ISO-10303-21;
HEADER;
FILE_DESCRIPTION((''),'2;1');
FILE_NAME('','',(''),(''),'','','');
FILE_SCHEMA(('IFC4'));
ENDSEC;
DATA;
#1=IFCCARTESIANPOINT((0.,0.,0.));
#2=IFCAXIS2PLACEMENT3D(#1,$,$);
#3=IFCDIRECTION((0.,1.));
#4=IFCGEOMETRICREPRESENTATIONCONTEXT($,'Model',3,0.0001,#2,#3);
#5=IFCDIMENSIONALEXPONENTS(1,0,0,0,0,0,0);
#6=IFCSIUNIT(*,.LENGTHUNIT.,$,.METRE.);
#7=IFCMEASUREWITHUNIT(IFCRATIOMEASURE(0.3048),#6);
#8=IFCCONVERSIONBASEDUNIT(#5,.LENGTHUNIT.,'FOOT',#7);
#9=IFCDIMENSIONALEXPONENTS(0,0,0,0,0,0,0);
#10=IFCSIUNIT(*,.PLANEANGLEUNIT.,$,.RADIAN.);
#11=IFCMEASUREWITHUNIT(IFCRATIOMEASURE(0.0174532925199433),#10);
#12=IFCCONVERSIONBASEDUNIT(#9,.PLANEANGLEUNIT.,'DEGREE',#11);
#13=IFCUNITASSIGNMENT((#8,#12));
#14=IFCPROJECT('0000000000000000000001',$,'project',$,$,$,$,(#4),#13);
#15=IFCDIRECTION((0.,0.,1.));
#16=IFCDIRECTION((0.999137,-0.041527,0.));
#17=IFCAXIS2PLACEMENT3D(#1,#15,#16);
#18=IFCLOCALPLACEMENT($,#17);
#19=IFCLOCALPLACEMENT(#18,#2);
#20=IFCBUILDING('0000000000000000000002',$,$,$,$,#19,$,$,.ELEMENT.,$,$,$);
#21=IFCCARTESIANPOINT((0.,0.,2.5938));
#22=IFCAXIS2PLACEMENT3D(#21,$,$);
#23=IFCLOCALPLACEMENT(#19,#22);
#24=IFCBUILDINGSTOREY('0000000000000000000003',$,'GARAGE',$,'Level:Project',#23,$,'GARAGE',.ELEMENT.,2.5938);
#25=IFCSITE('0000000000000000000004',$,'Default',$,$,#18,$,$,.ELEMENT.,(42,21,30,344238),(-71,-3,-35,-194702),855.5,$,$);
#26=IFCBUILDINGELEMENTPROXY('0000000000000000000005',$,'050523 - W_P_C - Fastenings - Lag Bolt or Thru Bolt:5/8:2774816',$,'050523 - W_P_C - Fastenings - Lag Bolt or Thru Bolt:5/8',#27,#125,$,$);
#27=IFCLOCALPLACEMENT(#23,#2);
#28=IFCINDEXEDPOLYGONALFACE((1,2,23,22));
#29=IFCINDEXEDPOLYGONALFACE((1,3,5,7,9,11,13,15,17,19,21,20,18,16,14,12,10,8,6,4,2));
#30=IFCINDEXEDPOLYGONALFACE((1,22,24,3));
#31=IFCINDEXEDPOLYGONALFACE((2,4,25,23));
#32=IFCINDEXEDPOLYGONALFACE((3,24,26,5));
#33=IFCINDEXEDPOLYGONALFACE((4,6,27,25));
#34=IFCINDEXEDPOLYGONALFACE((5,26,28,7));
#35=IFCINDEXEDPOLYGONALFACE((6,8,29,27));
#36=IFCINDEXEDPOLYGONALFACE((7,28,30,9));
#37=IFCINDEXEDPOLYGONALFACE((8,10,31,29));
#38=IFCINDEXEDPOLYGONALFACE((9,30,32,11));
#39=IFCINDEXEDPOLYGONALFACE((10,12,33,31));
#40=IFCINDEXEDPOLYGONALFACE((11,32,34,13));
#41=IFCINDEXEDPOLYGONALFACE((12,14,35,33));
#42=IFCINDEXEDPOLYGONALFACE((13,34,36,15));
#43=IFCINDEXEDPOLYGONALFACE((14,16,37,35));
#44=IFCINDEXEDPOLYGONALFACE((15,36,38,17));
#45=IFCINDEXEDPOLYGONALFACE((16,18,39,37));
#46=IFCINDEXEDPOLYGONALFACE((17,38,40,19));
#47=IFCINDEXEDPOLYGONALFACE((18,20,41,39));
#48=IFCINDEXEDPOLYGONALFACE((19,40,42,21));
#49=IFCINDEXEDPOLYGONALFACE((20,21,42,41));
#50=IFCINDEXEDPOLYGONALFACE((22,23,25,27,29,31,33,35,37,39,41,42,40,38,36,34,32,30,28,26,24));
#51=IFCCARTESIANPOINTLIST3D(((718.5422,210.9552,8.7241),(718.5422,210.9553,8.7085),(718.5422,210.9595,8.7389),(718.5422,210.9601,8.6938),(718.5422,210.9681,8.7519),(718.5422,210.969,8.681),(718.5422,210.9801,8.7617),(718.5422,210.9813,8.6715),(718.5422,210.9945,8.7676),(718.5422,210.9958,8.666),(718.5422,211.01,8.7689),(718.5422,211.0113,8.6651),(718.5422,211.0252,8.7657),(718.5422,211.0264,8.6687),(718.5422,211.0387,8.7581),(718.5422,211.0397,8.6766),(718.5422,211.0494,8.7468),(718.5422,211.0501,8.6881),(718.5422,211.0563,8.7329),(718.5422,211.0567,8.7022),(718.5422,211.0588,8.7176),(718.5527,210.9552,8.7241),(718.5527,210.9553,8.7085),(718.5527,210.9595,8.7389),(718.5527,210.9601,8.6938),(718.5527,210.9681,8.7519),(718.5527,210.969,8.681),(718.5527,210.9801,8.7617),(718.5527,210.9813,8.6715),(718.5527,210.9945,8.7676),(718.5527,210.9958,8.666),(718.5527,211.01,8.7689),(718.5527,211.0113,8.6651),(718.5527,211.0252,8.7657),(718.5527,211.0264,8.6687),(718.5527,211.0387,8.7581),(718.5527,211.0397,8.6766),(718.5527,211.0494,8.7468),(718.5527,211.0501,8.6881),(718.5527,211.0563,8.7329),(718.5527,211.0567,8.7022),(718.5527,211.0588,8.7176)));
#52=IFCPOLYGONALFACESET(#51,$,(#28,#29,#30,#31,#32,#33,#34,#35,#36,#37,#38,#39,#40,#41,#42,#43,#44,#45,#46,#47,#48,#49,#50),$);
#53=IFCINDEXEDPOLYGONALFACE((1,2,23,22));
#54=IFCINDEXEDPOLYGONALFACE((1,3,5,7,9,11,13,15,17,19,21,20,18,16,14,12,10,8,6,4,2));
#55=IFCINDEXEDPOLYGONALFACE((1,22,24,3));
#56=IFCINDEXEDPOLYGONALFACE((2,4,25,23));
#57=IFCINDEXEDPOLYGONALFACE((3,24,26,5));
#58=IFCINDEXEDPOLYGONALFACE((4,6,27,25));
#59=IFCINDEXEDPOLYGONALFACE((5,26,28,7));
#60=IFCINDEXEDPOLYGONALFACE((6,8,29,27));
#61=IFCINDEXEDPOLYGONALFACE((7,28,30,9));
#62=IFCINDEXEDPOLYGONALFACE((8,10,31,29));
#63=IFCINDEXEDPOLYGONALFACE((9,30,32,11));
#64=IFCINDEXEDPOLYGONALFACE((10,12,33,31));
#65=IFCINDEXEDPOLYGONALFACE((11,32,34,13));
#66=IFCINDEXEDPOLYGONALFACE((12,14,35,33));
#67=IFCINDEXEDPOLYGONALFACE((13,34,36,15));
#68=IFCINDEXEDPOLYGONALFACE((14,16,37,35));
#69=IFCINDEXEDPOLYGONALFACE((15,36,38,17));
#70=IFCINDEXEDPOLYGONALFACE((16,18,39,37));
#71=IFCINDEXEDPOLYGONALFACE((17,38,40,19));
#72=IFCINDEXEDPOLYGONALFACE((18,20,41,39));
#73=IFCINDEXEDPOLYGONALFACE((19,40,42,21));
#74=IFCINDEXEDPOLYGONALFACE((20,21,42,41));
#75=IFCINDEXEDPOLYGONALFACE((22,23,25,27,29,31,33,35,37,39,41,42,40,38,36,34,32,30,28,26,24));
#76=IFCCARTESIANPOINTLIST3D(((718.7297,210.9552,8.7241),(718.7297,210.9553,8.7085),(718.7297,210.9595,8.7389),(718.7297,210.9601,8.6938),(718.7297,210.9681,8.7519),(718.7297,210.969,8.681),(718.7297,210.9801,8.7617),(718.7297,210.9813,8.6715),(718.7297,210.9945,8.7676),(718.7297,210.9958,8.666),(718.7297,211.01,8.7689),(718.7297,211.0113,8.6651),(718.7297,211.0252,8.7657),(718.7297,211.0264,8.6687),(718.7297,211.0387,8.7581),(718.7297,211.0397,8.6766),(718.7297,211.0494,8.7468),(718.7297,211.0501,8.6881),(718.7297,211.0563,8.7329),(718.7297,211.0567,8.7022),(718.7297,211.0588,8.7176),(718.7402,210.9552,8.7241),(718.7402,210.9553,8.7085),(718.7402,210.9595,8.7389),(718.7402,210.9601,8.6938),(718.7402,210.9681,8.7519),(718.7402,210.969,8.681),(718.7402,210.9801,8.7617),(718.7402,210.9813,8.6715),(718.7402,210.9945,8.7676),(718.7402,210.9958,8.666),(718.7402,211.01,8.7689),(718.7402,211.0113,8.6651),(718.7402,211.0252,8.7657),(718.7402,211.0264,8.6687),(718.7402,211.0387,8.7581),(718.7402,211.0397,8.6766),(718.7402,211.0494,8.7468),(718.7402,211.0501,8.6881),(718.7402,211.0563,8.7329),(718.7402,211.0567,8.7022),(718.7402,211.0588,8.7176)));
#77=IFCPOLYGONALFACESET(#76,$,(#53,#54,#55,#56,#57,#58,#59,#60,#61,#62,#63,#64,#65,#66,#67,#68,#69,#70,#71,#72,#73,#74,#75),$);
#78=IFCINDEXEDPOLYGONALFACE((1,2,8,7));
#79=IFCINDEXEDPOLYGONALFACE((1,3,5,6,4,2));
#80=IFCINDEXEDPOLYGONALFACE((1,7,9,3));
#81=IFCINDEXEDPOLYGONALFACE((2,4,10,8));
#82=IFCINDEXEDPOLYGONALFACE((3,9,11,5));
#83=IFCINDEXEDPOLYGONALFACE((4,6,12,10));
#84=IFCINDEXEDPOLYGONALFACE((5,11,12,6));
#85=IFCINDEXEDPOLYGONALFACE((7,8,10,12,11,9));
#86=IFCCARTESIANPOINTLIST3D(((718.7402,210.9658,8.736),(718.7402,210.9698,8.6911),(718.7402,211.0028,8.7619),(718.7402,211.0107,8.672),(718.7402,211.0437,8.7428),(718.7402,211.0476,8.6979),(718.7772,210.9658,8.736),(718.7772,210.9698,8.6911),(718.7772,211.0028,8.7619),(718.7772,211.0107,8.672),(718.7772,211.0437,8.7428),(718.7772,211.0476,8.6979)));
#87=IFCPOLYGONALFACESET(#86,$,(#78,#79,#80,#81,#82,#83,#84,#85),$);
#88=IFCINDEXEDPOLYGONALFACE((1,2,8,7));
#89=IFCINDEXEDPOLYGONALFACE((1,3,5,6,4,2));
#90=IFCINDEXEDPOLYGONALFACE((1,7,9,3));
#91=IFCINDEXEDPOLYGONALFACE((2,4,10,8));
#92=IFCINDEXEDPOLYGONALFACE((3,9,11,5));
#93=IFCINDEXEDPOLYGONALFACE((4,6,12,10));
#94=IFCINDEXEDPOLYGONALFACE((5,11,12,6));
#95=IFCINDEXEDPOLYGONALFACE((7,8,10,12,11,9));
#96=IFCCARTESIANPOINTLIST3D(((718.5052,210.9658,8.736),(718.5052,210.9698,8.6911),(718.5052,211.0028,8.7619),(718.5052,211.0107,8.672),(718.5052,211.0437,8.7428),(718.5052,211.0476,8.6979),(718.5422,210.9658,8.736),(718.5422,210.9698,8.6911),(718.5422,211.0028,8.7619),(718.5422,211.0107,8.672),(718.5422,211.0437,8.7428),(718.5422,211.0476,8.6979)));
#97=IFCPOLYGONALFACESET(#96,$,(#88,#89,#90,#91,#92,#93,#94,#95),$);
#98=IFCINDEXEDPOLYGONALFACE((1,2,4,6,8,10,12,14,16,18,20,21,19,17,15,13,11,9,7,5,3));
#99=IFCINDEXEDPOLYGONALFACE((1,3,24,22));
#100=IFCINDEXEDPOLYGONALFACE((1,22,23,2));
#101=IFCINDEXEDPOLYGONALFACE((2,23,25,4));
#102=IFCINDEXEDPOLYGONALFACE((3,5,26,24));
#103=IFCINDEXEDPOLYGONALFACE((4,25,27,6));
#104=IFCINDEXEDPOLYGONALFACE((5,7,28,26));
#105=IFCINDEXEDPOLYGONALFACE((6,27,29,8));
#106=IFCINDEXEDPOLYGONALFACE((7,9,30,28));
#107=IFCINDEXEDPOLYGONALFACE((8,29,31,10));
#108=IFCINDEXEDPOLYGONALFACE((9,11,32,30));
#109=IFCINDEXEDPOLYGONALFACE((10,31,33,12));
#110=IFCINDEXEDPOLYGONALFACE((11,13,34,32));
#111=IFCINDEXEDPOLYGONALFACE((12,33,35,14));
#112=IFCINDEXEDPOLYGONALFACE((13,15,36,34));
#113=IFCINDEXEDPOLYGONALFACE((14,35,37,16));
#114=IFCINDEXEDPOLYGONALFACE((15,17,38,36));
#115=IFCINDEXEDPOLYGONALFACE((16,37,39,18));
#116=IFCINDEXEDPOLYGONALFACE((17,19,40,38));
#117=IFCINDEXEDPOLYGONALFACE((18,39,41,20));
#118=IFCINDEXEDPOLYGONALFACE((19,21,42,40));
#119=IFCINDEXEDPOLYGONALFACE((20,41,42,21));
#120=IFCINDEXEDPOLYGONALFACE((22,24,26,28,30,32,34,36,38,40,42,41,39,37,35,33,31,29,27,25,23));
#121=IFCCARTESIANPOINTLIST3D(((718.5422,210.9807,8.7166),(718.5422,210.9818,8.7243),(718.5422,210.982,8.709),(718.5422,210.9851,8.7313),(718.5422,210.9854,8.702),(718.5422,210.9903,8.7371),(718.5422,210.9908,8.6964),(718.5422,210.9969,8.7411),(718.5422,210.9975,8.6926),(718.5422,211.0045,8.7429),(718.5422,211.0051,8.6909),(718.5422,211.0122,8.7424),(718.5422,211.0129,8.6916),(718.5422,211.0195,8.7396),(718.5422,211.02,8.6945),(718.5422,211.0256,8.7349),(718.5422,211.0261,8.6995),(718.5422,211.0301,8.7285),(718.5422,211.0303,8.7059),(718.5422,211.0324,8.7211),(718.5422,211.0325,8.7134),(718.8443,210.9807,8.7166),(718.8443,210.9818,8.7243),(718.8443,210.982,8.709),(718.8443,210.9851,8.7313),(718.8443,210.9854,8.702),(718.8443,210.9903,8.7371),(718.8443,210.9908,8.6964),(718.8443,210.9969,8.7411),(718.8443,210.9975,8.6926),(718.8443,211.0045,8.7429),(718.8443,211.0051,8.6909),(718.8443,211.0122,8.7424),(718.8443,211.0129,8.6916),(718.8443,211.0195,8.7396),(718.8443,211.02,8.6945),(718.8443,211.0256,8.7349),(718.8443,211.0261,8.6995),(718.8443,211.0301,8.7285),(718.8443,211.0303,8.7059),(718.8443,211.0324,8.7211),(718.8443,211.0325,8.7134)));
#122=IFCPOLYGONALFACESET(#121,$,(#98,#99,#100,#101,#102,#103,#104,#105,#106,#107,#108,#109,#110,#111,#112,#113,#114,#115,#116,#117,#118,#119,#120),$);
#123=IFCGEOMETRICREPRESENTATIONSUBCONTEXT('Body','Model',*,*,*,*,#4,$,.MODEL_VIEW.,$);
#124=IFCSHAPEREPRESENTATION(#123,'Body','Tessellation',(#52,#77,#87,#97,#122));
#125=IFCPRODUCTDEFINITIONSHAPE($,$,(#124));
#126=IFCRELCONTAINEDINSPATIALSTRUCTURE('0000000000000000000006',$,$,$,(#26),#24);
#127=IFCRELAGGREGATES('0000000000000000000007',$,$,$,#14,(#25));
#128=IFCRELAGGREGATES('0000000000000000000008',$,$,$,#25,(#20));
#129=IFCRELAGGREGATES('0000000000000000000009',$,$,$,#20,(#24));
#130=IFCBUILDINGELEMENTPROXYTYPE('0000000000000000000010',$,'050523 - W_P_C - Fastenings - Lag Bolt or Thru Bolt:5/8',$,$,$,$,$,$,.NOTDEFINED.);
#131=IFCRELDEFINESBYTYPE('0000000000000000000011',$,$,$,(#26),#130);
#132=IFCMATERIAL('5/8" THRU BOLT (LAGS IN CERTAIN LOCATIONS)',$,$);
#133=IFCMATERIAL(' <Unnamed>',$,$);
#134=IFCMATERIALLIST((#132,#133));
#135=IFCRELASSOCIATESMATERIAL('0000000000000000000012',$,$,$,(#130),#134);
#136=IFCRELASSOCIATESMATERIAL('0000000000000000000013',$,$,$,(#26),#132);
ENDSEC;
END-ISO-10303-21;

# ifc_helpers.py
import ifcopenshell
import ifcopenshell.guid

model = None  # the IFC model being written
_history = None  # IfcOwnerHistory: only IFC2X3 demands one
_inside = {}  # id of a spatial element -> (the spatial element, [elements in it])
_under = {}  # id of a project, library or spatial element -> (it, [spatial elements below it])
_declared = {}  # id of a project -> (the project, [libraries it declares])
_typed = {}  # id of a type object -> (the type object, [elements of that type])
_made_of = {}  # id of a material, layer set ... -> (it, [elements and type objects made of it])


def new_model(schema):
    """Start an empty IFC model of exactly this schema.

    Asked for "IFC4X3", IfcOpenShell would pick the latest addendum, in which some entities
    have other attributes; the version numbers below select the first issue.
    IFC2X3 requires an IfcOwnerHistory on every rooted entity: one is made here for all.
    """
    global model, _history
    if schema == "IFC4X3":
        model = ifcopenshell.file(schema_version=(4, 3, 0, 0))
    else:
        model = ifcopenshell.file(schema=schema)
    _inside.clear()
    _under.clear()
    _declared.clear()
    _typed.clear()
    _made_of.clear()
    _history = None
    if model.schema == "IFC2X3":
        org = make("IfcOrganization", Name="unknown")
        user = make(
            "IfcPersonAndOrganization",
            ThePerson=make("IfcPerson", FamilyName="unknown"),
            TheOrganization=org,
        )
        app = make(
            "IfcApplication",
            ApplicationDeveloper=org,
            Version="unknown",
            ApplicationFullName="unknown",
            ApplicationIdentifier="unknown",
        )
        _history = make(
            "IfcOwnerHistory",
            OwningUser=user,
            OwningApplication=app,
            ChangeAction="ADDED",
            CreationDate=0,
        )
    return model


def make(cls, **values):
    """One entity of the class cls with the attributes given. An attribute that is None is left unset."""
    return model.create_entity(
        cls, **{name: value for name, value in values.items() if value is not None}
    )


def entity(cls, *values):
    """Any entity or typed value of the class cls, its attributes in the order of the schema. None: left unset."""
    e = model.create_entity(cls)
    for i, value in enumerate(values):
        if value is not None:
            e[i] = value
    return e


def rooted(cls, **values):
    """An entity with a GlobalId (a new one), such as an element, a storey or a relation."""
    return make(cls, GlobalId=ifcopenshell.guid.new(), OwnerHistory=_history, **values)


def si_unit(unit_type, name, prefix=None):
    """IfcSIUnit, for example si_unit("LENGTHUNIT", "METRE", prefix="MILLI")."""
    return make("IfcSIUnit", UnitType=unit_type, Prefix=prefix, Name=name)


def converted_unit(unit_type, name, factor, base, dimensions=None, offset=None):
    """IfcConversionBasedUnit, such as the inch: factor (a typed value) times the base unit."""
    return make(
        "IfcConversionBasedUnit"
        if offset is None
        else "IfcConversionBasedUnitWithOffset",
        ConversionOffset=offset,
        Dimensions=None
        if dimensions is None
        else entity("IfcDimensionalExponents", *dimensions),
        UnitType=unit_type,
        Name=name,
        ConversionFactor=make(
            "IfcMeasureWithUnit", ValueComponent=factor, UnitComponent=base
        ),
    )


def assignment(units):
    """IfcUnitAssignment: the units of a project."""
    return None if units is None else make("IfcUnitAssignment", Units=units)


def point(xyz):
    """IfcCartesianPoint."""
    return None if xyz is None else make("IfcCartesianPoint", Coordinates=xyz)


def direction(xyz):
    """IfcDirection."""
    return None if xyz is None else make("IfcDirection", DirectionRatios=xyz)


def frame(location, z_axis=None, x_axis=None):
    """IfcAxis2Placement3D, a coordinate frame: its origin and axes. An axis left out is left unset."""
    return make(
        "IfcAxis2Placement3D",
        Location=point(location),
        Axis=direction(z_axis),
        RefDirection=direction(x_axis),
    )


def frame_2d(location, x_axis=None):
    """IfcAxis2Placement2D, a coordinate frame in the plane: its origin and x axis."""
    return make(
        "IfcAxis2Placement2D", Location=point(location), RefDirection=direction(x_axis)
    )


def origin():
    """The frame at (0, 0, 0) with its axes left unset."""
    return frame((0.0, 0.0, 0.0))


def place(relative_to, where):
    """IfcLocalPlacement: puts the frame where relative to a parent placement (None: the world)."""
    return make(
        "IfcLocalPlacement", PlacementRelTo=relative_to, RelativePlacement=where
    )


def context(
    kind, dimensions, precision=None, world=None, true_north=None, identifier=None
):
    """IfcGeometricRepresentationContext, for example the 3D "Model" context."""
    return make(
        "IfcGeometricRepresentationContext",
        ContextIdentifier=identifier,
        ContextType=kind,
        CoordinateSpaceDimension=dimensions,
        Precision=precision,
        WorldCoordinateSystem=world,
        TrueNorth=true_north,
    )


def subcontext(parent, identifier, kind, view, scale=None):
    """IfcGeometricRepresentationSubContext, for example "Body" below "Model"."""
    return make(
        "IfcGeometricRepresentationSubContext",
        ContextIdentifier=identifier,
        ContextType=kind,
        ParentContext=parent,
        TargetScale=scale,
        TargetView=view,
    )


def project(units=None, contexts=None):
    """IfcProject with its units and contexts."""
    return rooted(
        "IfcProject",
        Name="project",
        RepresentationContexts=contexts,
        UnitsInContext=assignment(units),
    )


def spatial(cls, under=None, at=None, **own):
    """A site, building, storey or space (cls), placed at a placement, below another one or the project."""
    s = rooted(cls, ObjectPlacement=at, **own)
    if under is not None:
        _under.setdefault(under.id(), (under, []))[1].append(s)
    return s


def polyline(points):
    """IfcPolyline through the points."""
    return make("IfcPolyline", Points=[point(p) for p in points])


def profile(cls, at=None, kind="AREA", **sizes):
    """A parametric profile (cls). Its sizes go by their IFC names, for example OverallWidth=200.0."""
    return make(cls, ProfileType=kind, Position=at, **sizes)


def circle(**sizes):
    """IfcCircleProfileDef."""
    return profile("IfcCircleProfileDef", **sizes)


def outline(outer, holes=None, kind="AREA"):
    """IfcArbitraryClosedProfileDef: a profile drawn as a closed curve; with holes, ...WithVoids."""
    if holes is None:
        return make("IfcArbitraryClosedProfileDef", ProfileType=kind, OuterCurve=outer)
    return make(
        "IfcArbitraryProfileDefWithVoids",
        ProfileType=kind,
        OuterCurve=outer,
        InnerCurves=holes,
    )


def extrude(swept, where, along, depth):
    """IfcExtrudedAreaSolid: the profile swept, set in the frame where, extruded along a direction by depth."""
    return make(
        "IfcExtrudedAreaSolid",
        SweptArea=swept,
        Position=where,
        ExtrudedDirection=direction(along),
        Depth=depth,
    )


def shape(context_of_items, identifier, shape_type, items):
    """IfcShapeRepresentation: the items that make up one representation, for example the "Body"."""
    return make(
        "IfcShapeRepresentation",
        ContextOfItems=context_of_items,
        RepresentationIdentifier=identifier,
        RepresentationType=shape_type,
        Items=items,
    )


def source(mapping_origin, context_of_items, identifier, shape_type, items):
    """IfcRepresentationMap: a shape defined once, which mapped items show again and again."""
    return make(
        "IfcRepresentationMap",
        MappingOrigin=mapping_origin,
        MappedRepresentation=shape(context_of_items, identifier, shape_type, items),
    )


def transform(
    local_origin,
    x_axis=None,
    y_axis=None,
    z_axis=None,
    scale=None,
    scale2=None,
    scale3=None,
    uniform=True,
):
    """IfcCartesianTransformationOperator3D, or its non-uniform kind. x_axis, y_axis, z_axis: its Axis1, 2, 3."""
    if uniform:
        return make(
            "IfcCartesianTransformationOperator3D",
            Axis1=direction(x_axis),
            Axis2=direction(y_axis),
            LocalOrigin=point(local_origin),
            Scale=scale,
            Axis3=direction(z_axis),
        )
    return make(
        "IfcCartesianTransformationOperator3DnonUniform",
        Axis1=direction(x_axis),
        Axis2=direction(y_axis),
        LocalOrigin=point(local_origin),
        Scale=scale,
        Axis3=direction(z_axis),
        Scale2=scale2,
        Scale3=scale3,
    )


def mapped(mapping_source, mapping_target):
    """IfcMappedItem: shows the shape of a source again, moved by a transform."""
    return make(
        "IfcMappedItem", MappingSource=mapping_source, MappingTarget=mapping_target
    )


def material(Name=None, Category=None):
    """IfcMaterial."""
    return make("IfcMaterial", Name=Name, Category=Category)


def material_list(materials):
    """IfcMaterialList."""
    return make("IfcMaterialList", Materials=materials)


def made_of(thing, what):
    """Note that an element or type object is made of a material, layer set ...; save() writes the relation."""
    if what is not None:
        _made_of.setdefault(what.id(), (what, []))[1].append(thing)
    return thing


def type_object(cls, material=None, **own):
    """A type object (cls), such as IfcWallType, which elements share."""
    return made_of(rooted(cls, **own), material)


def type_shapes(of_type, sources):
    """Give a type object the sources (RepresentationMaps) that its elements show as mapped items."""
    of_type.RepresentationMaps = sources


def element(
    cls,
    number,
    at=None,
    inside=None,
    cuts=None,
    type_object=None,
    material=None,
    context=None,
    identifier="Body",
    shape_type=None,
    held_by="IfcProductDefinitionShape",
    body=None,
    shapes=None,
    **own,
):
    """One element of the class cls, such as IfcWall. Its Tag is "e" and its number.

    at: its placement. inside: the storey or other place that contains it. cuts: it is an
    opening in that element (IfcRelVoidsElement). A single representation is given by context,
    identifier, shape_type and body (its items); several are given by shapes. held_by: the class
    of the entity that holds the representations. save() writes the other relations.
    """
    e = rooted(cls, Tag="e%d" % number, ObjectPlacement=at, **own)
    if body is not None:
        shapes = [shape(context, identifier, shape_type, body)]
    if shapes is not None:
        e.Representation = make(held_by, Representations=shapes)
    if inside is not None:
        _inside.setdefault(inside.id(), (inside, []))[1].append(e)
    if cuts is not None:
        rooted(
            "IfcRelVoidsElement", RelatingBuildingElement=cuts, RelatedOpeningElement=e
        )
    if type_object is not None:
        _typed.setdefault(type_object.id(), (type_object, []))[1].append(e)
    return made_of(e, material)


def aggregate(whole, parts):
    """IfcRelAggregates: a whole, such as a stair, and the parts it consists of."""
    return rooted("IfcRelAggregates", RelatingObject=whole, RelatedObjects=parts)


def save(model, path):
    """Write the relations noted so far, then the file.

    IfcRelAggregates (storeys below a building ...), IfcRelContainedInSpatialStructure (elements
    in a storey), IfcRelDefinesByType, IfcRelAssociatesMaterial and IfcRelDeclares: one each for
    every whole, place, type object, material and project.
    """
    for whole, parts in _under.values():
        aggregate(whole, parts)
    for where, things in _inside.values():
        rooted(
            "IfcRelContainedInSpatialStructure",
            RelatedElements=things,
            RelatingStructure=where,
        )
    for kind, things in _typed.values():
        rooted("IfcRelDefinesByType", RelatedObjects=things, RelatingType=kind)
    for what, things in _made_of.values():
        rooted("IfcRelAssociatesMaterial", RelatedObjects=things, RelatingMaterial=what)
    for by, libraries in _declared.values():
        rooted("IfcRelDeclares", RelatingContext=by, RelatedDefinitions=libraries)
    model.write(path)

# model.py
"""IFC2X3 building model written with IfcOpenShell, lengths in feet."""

from ifc_helpers import new_model, entity, si_unit, converted_unit, direction, frame, frame_2d, origin, place, context, subcontext, project, spatial, polyline, circle, outline, extrude, source, transform, mapped, material, material_list, type_object, type_shapes, element, save


model = new_model("IFC2X3")

# Units and contexts
model_context = context("Model", 3, precision=0.0001, world=origin(), true_north=direction((0.0, 1.0)))
body_context = subcontext(model_context, "Body", "Model", "MODEL_VIEW")
ifc_project = project(units=[converted_unit("LENGTHUNIT", "FOOT", entity("IfcRatioMeasure", 0.3048), si_unit("LENGTHUNIT", "METRE"), dimensions=[1, 0, 0, 0, 0, 0, 0]), converted_unit("PLANEANGLEUNIT", "DEGREE", entity("IfcRatioMeasure", 0.0174532925199433), si_unit("PLANEANGLEUNIT", "RADIAN"), dimensions=[0, 0, 0, 0, 0, 0, 0])], contexts=[model_context])

# Site, building, storey
site_placement = place(None, frame((0.0, 0.0, 0.0), z_axis=(0.0, 0.0, 1.0), x_axis=(0.999137, -0.041527, 0.0)))
site = spatial("IfcSite", under=ifc_project, at=site_placement, Name="Default", CompositionType="ELEMENT", RefLatitude=(42, 21, 30, 344238), RefLongitude=(-71, -3, -35, -194702), RefElevation=855.5)
building_placement = place(site_placement, origin())
building = spatial("IfcBuilding", under=site, at=building_placement, CompositionType="ELEMENT")
storey_placement = place(building_placement, frame((0.0, 0.0, 2.5938)))
storey = spatial("IfcBuildingStorey", under=building, at=storey_placement, Name="GARAGE", ObjectType="Level:Project", LongName="GARAGE", CompositionType="ELEMENT", Elevation=2.5938)

# Building element proxy
ifc_material_1 = material(Name="5/8\" THRU BOLT (LAGS IN CERTAIN LOCATIONS)")
ifc_material_2 = material(Name=" <Unnamed>")
ifc_material_list_1 = material_list([ifc_material_1, ifc_material_2])
building_element_proxy_type_1 = type_object("IfcBuildingElementProxyType", Name="050523 - W_P_C - Fastenings - Lag Bolt or Thru Bolt:5/8", PredefinedType="NOTDEFINED", material=ifc_material_list_1)
shared_shape_1 = source(origin(), body_context, "Body", "SweptSolid", [
    extrude(circle(Radius=0.0521, at=frame_2d((0.0, 0.0), x_axis=(1.0, 0.0))), frame((0.0, 0.0, 0.0), z_axis=(0.0, 0.0, 1.0), x_axis=(0.0, -1.0, 0.0)), (0.0, 0.0, 1.0), 0.0104),
    extrude(circle(Radius=0.0521, at=frame_2d((0.0, 0.0), x_axis=(1.0, 0.0))), frame((0.0, 0.0, -0.1875), z_axis=(0.0, 0.0, 1.0), x_axis=(0.0, -1.0, 0.0)), (0.0, 0.0, 1.0), 0.0104),
    extrude(outline(polyline([(-0.0226, -0.0391), (0.0226, -0.0391), (0.0451, 0.0), (0.0226, 0.0391), (-0.0226, 0.0391), (-0.0451, 0.0), (-0.0226, -0.0391)])), frame((0.0, 0.0, -0.2245), z_axis=(0.0, 0.0, 1.0), x_axis=(0.866025, -0.5, 0.0)), (0.0, 0.0, 1.0), 0.037),
    extrude(outline(polyline([(-0.0226, -0.0391), (0.0226, -0.0391), (0.0451, 0.0), (0.0226, 0.0391), (-0.0226, 0.0391), (-0.0451, 0.0), (-0.0226, -0.0391)])), frame((0.0, 0.0, 0.0104), z_axis=(0.0, 0.0, 1.0), x_axis=(0.0, -1.0, 0.0)), (0.0, 0.0, 1.0), 0.037),
    extrude(circle(Radius=0.026, at=frame_2d((0.0, 0.0), x_axis=(1.0, 0.0))), frame((0.0, 0.0, -0.2917), z_axis=(0.0, 0.0, 1.0), x_axis=(0.0, 1.0, 0.0)), (0.0, 0.0, 1.0), 0.3021),
])
type_shapes(building_element_proxy_type_1, [shared_shape_1])
for number, where, z_axis, x_axis, name in (
    (1, (718.5527, 211.0067, 8.7169), (-1.0, 0.0, 0.0), (0.0, -0.996195, -0.087156), "050523 - W_P_C - Fastenings - Lag Bolt or Thru Bolt:5/8:2774816"),
):
    element("IfcBuildingElementProxy", number, at=place(storey_placement, frame(where, z_axis=z_axis, x_axis=x_axis)), inside=storey, type_object=building_element_proxy_type_1, material=ifc_material_1, Name=name, ObjectType="050523 - W_P_C - Fastenings - Lag Bolt or Thru Bolt:5/8", context=body_context, shape_type="MappedRepresentation", body=[
        mapped(shared_shape_1, transform((0.0, 0.0, 0.0), scale=1.0)),
    ])

save(model, "model.ifc")
